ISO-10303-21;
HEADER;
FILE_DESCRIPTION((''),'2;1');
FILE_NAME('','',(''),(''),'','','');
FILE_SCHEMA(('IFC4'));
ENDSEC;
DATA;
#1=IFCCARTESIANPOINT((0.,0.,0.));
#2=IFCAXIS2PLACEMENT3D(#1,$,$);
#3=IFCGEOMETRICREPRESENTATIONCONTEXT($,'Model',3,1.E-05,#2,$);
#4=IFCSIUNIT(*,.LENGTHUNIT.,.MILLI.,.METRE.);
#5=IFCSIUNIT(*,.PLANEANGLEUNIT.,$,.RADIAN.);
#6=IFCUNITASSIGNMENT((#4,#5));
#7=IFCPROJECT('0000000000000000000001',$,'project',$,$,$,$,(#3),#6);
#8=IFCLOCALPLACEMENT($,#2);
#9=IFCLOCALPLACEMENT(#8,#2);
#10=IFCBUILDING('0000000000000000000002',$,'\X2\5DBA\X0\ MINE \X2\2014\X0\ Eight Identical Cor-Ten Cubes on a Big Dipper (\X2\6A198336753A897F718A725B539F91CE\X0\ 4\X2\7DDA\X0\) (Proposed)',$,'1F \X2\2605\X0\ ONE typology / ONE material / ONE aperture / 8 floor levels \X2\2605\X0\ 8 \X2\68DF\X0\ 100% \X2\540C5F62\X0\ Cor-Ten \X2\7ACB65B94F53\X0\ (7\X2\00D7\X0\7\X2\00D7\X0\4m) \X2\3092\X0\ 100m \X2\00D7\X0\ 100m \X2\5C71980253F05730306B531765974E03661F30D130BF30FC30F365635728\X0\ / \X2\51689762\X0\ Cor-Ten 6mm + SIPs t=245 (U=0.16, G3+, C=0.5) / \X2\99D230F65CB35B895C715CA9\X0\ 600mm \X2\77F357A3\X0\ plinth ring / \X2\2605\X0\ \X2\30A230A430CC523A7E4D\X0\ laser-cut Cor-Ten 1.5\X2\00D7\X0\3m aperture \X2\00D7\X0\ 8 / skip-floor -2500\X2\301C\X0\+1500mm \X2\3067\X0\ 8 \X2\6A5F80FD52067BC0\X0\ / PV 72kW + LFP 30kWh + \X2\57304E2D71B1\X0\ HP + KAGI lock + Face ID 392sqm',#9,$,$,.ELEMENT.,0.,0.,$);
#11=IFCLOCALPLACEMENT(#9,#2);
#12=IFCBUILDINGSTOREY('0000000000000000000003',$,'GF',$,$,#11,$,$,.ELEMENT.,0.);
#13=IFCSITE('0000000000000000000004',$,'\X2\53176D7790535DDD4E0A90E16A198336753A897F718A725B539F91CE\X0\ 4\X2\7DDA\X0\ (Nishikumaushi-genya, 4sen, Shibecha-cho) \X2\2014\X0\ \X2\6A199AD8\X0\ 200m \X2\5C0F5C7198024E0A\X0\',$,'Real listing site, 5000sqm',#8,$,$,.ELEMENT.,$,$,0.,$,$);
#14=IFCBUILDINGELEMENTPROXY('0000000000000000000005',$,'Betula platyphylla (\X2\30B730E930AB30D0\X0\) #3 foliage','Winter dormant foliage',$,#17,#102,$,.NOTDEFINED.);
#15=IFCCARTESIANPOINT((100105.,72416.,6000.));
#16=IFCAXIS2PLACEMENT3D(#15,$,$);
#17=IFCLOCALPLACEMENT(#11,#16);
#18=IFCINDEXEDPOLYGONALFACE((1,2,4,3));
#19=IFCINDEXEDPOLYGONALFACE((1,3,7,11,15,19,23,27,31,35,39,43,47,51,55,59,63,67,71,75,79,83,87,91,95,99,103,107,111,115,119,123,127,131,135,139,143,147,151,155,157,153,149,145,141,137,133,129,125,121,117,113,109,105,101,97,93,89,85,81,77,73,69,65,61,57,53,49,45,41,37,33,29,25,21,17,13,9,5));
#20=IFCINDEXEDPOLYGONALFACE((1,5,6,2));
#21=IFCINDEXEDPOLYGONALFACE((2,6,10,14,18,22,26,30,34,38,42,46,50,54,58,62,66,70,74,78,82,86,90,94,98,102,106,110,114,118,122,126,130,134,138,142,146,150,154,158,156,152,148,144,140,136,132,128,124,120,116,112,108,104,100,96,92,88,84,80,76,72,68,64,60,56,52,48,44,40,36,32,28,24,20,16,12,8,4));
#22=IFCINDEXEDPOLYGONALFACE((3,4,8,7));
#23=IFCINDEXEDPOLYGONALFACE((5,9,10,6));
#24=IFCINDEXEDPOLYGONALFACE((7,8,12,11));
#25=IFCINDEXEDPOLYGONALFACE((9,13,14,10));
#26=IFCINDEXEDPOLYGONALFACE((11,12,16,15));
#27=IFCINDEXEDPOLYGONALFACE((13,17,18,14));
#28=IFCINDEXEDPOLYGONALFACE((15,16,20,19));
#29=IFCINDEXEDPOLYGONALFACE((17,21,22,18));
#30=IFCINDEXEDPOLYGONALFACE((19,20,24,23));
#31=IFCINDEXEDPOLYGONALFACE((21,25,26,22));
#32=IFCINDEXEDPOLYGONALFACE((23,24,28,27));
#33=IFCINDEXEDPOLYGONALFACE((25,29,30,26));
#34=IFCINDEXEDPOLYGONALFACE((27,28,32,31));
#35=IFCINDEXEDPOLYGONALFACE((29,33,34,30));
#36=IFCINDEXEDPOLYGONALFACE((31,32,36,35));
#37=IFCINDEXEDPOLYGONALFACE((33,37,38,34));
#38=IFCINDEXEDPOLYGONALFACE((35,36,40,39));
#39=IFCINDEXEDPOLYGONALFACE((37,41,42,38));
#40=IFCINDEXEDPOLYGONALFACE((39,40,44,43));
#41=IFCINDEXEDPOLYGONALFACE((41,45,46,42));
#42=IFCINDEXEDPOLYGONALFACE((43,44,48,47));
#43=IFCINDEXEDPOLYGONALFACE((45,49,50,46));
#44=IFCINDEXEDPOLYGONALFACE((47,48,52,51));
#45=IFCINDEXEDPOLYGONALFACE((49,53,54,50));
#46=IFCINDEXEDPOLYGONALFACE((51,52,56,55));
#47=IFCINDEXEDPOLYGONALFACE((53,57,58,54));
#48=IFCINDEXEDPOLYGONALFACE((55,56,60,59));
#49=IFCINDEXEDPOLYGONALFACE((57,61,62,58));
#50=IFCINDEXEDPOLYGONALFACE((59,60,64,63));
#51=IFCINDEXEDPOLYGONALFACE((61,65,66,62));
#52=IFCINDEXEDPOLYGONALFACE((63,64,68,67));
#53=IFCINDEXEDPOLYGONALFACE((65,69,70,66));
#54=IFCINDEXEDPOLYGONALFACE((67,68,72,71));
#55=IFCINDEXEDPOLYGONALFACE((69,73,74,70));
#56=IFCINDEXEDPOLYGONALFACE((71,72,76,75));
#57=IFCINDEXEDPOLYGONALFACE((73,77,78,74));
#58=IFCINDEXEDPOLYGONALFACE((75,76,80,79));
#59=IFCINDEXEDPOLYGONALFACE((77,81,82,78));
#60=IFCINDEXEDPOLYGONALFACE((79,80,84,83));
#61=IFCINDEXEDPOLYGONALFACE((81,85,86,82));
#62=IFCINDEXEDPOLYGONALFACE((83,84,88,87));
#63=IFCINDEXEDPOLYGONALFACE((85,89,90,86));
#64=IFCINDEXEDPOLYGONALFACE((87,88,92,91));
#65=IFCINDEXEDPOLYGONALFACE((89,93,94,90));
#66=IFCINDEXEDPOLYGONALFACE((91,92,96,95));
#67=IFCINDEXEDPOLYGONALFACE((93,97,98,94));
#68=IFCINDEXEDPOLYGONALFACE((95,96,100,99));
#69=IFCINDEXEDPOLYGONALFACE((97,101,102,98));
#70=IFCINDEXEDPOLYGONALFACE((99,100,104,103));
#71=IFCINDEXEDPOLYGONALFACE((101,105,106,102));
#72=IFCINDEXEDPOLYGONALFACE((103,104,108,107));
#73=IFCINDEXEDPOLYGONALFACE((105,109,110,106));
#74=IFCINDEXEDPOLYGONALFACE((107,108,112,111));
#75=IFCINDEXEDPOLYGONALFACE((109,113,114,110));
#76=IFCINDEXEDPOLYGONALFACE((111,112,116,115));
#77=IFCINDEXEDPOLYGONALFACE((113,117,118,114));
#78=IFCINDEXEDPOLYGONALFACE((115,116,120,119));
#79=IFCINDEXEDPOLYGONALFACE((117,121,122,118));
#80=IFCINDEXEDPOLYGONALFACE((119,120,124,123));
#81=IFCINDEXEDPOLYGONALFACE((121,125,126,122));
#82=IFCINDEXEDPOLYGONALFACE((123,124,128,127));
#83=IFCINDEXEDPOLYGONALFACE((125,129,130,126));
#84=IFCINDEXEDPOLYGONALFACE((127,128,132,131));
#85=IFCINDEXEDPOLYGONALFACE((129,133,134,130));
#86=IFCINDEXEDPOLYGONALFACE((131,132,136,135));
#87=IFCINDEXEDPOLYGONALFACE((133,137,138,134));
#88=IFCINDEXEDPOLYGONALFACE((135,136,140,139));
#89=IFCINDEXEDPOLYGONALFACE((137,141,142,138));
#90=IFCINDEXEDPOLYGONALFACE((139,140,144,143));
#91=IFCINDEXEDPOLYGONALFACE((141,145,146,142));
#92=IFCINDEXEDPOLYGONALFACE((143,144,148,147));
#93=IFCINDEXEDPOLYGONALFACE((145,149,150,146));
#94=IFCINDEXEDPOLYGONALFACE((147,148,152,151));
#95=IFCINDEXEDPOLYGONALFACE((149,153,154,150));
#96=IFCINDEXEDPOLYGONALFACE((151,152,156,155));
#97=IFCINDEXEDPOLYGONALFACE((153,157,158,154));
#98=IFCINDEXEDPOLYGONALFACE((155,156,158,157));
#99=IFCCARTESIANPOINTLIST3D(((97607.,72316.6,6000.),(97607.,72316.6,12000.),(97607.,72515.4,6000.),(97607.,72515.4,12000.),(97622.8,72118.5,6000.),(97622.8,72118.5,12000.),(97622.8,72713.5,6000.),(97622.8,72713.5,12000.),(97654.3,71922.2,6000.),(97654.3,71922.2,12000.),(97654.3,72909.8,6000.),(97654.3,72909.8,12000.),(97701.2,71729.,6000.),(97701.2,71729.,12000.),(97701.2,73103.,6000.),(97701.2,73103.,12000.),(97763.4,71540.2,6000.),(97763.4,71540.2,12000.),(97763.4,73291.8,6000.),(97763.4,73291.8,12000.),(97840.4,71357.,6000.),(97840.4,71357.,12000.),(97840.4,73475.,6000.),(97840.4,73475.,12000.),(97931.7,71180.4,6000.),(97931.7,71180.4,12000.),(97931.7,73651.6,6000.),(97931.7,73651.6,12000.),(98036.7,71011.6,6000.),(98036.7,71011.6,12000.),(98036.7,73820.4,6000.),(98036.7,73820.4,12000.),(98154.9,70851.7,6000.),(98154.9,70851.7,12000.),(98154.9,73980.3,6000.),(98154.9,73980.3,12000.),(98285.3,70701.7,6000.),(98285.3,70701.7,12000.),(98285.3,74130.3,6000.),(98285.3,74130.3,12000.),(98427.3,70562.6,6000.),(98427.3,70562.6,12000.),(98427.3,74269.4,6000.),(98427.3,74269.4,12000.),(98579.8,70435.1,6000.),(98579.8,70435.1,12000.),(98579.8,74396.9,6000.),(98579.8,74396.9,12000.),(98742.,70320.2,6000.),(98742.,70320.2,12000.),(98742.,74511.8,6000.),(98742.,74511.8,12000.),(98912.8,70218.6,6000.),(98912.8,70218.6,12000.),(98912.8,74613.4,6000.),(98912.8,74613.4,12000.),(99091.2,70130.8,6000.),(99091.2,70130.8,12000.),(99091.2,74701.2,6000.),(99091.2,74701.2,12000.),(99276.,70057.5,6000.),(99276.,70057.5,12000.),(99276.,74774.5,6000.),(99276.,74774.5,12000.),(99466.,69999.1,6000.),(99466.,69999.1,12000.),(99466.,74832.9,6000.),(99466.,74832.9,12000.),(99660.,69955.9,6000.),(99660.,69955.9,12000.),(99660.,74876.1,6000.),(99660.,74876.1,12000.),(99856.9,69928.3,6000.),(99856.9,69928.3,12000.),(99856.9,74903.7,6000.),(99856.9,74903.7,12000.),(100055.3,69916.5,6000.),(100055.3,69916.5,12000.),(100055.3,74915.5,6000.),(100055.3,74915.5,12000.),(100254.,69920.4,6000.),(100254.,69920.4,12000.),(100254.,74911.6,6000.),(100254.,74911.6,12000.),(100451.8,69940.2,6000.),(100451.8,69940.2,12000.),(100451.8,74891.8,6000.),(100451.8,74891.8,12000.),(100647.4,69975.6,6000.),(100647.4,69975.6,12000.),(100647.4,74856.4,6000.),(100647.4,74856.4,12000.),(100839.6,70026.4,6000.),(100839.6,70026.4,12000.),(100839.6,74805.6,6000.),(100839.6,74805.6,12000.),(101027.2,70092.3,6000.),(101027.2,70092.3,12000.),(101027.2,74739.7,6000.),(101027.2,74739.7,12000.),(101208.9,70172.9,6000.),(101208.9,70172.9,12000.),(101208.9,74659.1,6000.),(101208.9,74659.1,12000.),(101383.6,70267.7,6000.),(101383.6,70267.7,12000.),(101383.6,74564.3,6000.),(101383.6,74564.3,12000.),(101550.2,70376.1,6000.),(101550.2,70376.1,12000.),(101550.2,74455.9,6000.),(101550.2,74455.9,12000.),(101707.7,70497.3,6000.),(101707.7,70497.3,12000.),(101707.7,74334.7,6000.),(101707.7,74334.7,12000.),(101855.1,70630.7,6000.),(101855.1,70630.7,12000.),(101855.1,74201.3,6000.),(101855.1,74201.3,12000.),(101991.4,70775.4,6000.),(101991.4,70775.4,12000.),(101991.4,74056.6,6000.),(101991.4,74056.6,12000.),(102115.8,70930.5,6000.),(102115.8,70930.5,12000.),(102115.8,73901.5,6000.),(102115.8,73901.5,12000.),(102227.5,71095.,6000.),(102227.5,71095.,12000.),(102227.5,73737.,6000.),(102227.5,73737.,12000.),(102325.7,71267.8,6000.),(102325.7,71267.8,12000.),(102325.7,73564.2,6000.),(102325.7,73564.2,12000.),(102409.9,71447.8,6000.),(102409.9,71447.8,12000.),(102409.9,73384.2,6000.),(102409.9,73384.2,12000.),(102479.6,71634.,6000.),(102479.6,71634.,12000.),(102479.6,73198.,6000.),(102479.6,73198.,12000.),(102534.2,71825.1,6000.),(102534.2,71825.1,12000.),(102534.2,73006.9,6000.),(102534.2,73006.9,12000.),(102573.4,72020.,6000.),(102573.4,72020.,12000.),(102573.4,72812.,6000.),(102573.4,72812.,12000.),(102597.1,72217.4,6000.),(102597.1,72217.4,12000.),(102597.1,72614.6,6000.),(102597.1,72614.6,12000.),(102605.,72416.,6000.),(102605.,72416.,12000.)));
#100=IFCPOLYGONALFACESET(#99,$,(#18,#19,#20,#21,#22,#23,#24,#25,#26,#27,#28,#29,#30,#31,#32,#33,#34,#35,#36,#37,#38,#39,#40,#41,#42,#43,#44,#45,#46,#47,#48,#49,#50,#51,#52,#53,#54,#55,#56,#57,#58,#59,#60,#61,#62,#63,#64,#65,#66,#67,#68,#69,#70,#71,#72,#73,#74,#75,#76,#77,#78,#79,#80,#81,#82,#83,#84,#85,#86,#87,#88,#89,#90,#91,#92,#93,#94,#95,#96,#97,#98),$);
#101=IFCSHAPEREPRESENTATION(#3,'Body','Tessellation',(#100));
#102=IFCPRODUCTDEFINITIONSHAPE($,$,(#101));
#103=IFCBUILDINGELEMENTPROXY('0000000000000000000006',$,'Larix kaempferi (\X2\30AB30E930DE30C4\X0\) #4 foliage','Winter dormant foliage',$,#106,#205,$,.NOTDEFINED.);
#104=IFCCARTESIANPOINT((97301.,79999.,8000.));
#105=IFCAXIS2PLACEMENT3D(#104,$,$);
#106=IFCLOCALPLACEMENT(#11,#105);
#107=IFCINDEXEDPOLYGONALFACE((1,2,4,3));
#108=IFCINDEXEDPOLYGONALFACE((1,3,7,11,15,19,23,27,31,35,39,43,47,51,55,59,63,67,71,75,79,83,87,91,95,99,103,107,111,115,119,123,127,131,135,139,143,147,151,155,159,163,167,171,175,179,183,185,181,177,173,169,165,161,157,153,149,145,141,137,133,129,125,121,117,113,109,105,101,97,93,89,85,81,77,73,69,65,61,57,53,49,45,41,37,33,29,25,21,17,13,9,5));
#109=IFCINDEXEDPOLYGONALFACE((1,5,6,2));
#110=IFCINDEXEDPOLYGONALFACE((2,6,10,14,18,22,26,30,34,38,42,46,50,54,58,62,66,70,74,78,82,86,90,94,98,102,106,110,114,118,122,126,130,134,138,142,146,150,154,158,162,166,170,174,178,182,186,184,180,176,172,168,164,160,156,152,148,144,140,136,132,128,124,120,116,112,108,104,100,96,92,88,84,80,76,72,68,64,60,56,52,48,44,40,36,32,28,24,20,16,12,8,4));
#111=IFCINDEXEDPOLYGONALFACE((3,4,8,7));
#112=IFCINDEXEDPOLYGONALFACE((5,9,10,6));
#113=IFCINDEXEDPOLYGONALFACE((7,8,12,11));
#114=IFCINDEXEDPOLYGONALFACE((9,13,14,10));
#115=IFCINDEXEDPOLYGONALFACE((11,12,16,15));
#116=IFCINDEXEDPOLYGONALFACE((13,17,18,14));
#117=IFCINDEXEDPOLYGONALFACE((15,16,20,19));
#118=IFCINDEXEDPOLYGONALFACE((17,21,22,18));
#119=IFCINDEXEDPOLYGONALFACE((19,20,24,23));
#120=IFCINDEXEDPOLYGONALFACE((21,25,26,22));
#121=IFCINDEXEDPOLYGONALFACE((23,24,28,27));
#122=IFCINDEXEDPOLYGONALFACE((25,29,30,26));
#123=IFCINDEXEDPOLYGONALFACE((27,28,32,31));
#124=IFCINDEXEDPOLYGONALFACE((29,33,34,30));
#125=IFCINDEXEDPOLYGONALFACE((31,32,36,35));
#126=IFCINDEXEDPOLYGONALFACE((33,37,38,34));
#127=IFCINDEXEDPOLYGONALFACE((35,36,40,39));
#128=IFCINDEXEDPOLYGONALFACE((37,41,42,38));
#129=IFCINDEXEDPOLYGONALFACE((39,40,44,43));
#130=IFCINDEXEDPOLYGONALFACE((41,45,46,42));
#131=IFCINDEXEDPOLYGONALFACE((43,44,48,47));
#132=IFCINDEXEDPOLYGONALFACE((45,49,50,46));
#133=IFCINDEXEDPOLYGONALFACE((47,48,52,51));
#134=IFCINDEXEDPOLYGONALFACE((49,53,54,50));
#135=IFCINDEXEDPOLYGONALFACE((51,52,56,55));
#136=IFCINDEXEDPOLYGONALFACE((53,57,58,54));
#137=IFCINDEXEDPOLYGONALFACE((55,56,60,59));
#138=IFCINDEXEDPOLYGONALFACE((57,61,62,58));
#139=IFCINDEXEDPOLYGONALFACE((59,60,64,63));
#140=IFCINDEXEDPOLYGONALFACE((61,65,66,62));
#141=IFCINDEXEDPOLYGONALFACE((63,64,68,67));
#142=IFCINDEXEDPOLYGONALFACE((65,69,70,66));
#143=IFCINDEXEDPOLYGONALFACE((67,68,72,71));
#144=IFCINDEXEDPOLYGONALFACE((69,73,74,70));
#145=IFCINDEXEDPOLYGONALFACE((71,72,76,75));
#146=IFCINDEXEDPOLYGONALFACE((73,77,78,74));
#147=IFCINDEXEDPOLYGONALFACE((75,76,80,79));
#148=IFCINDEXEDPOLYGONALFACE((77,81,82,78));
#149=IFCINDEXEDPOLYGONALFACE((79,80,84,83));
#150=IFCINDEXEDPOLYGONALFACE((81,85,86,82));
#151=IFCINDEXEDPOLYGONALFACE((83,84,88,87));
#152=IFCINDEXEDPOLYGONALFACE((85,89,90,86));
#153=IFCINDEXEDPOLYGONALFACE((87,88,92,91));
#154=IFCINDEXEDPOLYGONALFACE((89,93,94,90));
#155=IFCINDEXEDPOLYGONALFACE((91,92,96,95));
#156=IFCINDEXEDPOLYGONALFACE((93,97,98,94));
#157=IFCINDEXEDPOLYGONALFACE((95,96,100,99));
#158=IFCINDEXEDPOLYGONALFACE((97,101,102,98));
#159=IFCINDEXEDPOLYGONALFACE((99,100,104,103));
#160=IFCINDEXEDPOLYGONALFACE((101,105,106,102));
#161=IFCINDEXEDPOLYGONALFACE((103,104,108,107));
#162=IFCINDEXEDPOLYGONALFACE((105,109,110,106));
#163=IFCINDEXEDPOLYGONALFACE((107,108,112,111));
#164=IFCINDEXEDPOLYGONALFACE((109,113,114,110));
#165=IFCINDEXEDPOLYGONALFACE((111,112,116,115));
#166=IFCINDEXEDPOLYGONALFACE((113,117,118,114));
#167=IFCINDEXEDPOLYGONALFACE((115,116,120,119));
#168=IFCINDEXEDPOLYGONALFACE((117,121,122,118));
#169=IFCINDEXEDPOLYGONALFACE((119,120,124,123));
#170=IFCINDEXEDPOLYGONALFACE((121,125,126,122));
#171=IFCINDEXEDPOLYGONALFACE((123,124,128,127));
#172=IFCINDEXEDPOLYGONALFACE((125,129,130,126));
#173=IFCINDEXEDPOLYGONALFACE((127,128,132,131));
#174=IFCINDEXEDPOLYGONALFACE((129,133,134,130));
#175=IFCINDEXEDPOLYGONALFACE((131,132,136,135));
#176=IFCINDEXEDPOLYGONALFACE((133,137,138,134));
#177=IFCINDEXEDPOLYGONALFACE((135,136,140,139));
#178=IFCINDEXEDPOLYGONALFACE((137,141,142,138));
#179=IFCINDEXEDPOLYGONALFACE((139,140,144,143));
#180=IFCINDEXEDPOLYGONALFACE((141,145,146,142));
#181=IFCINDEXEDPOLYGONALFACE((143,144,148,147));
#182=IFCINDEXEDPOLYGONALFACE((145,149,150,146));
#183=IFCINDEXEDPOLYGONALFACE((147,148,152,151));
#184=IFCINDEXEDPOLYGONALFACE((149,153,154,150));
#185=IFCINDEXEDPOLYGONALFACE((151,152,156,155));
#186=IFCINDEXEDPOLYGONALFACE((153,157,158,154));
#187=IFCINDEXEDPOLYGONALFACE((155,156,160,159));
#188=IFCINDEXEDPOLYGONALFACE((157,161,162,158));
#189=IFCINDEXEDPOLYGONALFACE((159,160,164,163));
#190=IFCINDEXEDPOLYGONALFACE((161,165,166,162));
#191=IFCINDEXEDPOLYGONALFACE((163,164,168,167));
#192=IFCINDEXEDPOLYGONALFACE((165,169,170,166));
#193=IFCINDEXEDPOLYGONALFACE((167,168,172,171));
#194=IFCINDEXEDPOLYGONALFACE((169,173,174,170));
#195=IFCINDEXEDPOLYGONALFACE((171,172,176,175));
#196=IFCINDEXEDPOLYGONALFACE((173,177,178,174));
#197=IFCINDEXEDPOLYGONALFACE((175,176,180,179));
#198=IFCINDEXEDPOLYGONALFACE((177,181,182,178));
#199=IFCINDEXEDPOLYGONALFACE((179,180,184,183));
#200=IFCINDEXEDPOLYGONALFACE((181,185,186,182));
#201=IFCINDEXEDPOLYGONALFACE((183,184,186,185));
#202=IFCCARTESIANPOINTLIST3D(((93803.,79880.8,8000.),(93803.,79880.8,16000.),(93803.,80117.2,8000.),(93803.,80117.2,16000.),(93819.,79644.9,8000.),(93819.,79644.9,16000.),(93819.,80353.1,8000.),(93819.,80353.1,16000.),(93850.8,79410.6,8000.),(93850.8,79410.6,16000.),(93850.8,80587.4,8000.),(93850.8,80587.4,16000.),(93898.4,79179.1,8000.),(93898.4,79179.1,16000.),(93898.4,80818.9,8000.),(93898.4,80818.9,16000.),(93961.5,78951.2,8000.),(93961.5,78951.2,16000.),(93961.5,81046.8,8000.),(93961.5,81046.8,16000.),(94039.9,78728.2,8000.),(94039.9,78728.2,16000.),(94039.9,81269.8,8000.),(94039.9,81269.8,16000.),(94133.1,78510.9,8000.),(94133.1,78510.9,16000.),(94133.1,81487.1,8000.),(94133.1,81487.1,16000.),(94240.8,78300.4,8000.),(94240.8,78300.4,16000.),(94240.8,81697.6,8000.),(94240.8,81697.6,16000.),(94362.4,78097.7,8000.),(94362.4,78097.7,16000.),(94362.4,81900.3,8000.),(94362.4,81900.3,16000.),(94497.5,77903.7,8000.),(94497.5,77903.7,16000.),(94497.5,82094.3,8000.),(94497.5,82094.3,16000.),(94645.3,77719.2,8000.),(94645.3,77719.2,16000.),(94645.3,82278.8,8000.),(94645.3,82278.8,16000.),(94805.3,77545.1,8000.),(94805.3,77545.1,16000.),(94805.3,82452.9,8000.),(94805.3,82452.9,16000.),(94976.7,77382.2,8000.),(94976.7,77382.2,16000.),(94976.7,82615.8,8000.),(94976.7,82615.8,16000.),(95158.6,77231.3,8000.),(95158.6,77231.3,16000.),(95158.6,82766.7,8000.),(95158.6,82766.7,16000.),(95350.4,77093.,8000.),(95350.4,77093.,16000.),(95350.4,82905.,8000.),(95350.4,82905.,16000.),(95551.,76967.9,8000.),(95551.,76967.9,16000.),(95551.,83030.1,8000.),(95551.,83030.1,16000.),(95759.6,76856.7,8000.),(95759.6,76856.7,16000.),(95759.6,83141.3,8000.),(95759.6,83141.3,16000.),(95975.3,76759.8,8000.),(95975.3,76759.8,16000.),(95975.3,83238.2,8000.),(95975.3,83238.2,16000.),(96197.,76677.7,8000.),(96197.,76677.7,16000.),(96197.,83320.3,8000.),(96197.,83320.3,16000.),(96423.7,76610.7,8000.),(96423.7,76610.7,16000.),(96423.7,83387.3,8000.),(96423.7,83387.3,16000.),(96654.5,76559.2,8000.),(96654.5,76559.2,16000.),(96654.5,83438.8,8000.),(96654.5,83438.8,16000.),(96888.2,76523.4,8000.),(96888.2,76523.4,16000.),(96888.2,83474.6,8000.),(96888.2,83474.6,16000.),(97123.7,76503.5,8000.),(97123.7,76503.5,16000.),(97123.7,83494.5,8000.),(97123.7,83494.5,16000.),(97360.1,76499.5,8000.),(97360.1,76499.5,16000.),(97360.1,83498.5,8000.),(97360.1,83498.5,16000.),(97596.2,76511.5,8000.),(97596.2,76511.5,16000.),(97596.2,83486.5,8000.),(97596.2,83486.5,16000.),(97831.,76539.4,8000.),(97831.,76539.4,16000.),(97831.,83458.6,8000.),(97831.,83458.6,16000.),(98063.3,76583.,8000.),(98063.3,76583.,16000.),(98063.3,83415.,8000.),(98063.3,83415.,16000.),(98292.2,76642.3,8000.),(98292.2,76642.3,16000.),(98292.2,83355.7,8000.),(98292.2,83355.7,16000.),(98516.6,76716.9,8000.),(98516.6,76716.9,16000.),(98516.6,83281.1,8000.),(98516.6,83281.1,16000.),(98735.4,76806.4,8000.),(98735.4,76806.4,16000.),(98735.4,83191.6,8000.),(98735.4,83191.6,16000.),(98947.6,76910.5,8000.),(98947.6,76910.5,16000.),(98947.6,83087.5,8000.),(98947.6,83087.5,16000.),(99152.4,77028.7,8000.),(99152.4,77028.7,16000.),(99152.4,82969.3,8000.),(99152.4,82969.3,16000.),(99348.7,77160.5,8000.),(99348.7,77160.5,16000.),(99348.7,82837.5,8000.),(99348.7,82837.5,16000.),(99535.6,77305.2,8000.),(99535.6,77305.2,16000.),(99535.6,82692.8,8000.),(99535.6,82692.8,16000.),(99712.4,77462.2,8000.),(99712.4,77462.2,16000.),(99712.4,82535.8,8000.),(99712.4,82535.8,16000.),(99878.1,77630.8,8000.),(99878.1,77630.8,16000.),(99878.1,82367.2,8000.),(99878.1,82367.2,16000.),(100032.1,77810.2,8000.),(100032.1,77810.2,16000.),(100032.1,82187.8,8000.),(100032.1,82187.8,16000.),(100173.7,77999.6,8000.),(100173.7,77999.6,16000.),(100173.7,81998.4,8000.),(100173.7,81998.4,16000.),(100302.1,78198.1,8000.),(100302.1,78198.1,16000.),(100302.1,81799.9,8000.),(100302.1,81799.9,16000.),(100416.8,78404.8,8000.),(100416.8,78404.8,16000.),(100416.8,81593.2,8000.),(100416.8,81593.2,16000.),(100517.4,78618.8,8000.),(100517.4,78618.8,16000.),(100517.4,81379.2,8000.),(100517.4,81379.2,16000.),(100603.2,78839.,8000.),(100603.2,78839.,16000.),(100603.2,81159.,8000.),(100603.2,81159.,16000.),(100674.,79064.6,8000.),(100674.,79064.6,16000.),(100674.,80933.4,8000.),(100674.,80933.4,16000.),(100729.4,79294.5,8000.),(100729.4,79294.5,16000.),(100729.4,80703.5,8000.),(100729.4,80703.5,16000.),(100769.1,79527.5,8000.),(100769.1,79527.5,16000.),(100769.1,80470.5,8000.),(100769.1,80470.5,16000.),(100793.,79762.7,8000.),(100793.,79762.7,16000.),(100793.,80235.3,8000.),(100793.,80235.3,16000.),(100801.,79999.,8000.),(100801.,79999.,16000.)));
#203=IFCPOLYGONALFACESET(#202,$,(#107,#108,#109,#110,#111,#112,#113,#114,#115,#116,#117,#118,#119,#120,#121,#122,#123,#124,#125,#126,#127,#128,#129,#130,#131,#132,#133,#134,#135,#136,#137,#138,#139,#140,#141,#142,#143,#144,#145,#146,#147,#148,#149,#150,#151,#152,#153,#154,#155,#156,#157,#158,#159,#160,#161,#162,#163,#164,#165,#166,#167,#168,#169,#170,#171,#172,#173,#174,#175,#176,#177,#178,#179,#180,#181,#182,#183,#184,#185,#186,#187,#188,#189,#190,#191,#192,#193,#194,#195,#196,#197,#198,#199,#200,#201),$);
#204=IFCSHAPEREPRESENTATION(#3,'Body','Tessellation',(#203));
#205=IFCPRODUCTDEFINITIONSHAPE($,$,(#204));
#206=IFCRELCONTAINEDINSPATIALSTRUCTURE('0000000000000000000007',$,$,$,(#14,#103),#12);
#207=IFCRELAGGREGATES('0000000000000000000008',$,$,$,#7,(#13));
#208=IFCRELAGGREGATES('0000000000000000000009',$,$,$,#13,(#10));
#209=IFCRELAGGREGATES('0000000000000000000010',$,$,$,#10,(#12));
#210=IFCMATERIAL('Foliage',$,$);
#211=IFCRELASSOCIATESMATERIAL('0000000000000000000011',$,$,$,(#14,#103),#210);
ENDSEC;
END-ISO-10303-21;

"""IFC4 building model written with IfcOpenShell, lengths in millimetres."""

from ifc_helpers import new_model, si_unit, frame, origin, origin_2d, place, context, project, spatial, circle, extrude, material, element, save


model = new_model("IFC4")

# Units and contexts
model_context = context("Model", 3, precision=1e-05, world=origin())
ifc_project = project(units=[si_unit("LENGTHUNIT", "METRE", prefix="MILLI"), si_unit("PLANEANGLEUNIT", "RADIAN")], contexts=[model_context])

# Site, building, storey
site_placement = place(None, origin())
site = spatial("IfcSite", under=ifc_project, at=site_placement, Name="北海道川上郡標茶町西熊牛原野 4線 (Nishikumaushi-genya, 4sen, Shibecha-cho) — 標高 200m 小山頂上", ObjectType="Real listing site, 5000sqm", CompositionType="ELEMENT", RefElevation=0.0)
building_placement = place(site_placement, origin())
building = spatial("IfcBuilding", under=site, at=building_placement, Name="嶺 MINE — Eight Identical Cor-Ten Cubes on a Big Dipper (標茶町西熊牛原野 4線) (Proposed)", ObjectType="1F ★ ONE typology / ONE material / ONE aperture / 8 floor levels ★ 8 棟 100% 同形 Cor-Ten 立方体 (7×7×4m) を 100m × 100m 山頂台地に北斗七星パターン散在 / 全面 Cor-Ten 6mm + SIPs t=245 (U=0.16, G3+, C=0.5) / 駒ヶ岳安山岩 600mm 石垣 plinth ring / ★ アイヌ刺繍 laser-cut Cor-Ten 1.5×3m aperture × 8 / skip-floor -2500〜+1500mm で 8 機能分節 / PV 72kW + LFP 30kWh + 地中熱 HP + KAGI lock + Face ID 392sqm", CompositionType="ELEMENT", ElevationOfRefHeight=0.0, ElevationOfTerrain=0.0)
storey_placement = place(building_placement, origin())
storey = spatial("IfcBuildingStorey", under=building, at=storey_placement, Name="GF", CompositionType="ELEMENT", Elevation=0.0)

# Building element proxies
ifc_material_1 = material(Name="Foliage")
proxy_1_placement = place(storey_placement, frame((100105.0, 72416.0, 6000.0)))
element("IfcBuildingElementProxy", 1, at=proxy_1_placement, inside=storey, material=ifc_material_1, Name="Betula platyphylla (シラカバ) #3 foliage", Description="Winter dormant foliage", PredefinedType="NOTDEFINED", context=model_context, shape_type="SweptSolid", body=[
    extrude(circle(Radius=2500.0, at=origin_2d()), frame((100105.0, 72416.0, 6000.0)), (0.0, 0.0, 1.0), 6000.0),
])
proxy_2_placement = place(storey_placement, frame((97301.0, 79999.0, 8000.0)))
element("IfcBuildingElementProxy", 2, at=proxy_2_placement, inside=storey, material=ifc_material_1, Name="Larix kaempferi (カラマツ) #4 foliage", Description="Winter dormant foliage", PredefinedType="NOTDEFINED", context=model_context, shape_type="SweptSolid", body=[
    extrude(circle(Radius=3500.0, at=origin_2d()), frame((97301.0, 79999.0, 8000.0)), (0.0, 0.0, 1.0), 8000.0),
])

save(model, "model.ifc")
